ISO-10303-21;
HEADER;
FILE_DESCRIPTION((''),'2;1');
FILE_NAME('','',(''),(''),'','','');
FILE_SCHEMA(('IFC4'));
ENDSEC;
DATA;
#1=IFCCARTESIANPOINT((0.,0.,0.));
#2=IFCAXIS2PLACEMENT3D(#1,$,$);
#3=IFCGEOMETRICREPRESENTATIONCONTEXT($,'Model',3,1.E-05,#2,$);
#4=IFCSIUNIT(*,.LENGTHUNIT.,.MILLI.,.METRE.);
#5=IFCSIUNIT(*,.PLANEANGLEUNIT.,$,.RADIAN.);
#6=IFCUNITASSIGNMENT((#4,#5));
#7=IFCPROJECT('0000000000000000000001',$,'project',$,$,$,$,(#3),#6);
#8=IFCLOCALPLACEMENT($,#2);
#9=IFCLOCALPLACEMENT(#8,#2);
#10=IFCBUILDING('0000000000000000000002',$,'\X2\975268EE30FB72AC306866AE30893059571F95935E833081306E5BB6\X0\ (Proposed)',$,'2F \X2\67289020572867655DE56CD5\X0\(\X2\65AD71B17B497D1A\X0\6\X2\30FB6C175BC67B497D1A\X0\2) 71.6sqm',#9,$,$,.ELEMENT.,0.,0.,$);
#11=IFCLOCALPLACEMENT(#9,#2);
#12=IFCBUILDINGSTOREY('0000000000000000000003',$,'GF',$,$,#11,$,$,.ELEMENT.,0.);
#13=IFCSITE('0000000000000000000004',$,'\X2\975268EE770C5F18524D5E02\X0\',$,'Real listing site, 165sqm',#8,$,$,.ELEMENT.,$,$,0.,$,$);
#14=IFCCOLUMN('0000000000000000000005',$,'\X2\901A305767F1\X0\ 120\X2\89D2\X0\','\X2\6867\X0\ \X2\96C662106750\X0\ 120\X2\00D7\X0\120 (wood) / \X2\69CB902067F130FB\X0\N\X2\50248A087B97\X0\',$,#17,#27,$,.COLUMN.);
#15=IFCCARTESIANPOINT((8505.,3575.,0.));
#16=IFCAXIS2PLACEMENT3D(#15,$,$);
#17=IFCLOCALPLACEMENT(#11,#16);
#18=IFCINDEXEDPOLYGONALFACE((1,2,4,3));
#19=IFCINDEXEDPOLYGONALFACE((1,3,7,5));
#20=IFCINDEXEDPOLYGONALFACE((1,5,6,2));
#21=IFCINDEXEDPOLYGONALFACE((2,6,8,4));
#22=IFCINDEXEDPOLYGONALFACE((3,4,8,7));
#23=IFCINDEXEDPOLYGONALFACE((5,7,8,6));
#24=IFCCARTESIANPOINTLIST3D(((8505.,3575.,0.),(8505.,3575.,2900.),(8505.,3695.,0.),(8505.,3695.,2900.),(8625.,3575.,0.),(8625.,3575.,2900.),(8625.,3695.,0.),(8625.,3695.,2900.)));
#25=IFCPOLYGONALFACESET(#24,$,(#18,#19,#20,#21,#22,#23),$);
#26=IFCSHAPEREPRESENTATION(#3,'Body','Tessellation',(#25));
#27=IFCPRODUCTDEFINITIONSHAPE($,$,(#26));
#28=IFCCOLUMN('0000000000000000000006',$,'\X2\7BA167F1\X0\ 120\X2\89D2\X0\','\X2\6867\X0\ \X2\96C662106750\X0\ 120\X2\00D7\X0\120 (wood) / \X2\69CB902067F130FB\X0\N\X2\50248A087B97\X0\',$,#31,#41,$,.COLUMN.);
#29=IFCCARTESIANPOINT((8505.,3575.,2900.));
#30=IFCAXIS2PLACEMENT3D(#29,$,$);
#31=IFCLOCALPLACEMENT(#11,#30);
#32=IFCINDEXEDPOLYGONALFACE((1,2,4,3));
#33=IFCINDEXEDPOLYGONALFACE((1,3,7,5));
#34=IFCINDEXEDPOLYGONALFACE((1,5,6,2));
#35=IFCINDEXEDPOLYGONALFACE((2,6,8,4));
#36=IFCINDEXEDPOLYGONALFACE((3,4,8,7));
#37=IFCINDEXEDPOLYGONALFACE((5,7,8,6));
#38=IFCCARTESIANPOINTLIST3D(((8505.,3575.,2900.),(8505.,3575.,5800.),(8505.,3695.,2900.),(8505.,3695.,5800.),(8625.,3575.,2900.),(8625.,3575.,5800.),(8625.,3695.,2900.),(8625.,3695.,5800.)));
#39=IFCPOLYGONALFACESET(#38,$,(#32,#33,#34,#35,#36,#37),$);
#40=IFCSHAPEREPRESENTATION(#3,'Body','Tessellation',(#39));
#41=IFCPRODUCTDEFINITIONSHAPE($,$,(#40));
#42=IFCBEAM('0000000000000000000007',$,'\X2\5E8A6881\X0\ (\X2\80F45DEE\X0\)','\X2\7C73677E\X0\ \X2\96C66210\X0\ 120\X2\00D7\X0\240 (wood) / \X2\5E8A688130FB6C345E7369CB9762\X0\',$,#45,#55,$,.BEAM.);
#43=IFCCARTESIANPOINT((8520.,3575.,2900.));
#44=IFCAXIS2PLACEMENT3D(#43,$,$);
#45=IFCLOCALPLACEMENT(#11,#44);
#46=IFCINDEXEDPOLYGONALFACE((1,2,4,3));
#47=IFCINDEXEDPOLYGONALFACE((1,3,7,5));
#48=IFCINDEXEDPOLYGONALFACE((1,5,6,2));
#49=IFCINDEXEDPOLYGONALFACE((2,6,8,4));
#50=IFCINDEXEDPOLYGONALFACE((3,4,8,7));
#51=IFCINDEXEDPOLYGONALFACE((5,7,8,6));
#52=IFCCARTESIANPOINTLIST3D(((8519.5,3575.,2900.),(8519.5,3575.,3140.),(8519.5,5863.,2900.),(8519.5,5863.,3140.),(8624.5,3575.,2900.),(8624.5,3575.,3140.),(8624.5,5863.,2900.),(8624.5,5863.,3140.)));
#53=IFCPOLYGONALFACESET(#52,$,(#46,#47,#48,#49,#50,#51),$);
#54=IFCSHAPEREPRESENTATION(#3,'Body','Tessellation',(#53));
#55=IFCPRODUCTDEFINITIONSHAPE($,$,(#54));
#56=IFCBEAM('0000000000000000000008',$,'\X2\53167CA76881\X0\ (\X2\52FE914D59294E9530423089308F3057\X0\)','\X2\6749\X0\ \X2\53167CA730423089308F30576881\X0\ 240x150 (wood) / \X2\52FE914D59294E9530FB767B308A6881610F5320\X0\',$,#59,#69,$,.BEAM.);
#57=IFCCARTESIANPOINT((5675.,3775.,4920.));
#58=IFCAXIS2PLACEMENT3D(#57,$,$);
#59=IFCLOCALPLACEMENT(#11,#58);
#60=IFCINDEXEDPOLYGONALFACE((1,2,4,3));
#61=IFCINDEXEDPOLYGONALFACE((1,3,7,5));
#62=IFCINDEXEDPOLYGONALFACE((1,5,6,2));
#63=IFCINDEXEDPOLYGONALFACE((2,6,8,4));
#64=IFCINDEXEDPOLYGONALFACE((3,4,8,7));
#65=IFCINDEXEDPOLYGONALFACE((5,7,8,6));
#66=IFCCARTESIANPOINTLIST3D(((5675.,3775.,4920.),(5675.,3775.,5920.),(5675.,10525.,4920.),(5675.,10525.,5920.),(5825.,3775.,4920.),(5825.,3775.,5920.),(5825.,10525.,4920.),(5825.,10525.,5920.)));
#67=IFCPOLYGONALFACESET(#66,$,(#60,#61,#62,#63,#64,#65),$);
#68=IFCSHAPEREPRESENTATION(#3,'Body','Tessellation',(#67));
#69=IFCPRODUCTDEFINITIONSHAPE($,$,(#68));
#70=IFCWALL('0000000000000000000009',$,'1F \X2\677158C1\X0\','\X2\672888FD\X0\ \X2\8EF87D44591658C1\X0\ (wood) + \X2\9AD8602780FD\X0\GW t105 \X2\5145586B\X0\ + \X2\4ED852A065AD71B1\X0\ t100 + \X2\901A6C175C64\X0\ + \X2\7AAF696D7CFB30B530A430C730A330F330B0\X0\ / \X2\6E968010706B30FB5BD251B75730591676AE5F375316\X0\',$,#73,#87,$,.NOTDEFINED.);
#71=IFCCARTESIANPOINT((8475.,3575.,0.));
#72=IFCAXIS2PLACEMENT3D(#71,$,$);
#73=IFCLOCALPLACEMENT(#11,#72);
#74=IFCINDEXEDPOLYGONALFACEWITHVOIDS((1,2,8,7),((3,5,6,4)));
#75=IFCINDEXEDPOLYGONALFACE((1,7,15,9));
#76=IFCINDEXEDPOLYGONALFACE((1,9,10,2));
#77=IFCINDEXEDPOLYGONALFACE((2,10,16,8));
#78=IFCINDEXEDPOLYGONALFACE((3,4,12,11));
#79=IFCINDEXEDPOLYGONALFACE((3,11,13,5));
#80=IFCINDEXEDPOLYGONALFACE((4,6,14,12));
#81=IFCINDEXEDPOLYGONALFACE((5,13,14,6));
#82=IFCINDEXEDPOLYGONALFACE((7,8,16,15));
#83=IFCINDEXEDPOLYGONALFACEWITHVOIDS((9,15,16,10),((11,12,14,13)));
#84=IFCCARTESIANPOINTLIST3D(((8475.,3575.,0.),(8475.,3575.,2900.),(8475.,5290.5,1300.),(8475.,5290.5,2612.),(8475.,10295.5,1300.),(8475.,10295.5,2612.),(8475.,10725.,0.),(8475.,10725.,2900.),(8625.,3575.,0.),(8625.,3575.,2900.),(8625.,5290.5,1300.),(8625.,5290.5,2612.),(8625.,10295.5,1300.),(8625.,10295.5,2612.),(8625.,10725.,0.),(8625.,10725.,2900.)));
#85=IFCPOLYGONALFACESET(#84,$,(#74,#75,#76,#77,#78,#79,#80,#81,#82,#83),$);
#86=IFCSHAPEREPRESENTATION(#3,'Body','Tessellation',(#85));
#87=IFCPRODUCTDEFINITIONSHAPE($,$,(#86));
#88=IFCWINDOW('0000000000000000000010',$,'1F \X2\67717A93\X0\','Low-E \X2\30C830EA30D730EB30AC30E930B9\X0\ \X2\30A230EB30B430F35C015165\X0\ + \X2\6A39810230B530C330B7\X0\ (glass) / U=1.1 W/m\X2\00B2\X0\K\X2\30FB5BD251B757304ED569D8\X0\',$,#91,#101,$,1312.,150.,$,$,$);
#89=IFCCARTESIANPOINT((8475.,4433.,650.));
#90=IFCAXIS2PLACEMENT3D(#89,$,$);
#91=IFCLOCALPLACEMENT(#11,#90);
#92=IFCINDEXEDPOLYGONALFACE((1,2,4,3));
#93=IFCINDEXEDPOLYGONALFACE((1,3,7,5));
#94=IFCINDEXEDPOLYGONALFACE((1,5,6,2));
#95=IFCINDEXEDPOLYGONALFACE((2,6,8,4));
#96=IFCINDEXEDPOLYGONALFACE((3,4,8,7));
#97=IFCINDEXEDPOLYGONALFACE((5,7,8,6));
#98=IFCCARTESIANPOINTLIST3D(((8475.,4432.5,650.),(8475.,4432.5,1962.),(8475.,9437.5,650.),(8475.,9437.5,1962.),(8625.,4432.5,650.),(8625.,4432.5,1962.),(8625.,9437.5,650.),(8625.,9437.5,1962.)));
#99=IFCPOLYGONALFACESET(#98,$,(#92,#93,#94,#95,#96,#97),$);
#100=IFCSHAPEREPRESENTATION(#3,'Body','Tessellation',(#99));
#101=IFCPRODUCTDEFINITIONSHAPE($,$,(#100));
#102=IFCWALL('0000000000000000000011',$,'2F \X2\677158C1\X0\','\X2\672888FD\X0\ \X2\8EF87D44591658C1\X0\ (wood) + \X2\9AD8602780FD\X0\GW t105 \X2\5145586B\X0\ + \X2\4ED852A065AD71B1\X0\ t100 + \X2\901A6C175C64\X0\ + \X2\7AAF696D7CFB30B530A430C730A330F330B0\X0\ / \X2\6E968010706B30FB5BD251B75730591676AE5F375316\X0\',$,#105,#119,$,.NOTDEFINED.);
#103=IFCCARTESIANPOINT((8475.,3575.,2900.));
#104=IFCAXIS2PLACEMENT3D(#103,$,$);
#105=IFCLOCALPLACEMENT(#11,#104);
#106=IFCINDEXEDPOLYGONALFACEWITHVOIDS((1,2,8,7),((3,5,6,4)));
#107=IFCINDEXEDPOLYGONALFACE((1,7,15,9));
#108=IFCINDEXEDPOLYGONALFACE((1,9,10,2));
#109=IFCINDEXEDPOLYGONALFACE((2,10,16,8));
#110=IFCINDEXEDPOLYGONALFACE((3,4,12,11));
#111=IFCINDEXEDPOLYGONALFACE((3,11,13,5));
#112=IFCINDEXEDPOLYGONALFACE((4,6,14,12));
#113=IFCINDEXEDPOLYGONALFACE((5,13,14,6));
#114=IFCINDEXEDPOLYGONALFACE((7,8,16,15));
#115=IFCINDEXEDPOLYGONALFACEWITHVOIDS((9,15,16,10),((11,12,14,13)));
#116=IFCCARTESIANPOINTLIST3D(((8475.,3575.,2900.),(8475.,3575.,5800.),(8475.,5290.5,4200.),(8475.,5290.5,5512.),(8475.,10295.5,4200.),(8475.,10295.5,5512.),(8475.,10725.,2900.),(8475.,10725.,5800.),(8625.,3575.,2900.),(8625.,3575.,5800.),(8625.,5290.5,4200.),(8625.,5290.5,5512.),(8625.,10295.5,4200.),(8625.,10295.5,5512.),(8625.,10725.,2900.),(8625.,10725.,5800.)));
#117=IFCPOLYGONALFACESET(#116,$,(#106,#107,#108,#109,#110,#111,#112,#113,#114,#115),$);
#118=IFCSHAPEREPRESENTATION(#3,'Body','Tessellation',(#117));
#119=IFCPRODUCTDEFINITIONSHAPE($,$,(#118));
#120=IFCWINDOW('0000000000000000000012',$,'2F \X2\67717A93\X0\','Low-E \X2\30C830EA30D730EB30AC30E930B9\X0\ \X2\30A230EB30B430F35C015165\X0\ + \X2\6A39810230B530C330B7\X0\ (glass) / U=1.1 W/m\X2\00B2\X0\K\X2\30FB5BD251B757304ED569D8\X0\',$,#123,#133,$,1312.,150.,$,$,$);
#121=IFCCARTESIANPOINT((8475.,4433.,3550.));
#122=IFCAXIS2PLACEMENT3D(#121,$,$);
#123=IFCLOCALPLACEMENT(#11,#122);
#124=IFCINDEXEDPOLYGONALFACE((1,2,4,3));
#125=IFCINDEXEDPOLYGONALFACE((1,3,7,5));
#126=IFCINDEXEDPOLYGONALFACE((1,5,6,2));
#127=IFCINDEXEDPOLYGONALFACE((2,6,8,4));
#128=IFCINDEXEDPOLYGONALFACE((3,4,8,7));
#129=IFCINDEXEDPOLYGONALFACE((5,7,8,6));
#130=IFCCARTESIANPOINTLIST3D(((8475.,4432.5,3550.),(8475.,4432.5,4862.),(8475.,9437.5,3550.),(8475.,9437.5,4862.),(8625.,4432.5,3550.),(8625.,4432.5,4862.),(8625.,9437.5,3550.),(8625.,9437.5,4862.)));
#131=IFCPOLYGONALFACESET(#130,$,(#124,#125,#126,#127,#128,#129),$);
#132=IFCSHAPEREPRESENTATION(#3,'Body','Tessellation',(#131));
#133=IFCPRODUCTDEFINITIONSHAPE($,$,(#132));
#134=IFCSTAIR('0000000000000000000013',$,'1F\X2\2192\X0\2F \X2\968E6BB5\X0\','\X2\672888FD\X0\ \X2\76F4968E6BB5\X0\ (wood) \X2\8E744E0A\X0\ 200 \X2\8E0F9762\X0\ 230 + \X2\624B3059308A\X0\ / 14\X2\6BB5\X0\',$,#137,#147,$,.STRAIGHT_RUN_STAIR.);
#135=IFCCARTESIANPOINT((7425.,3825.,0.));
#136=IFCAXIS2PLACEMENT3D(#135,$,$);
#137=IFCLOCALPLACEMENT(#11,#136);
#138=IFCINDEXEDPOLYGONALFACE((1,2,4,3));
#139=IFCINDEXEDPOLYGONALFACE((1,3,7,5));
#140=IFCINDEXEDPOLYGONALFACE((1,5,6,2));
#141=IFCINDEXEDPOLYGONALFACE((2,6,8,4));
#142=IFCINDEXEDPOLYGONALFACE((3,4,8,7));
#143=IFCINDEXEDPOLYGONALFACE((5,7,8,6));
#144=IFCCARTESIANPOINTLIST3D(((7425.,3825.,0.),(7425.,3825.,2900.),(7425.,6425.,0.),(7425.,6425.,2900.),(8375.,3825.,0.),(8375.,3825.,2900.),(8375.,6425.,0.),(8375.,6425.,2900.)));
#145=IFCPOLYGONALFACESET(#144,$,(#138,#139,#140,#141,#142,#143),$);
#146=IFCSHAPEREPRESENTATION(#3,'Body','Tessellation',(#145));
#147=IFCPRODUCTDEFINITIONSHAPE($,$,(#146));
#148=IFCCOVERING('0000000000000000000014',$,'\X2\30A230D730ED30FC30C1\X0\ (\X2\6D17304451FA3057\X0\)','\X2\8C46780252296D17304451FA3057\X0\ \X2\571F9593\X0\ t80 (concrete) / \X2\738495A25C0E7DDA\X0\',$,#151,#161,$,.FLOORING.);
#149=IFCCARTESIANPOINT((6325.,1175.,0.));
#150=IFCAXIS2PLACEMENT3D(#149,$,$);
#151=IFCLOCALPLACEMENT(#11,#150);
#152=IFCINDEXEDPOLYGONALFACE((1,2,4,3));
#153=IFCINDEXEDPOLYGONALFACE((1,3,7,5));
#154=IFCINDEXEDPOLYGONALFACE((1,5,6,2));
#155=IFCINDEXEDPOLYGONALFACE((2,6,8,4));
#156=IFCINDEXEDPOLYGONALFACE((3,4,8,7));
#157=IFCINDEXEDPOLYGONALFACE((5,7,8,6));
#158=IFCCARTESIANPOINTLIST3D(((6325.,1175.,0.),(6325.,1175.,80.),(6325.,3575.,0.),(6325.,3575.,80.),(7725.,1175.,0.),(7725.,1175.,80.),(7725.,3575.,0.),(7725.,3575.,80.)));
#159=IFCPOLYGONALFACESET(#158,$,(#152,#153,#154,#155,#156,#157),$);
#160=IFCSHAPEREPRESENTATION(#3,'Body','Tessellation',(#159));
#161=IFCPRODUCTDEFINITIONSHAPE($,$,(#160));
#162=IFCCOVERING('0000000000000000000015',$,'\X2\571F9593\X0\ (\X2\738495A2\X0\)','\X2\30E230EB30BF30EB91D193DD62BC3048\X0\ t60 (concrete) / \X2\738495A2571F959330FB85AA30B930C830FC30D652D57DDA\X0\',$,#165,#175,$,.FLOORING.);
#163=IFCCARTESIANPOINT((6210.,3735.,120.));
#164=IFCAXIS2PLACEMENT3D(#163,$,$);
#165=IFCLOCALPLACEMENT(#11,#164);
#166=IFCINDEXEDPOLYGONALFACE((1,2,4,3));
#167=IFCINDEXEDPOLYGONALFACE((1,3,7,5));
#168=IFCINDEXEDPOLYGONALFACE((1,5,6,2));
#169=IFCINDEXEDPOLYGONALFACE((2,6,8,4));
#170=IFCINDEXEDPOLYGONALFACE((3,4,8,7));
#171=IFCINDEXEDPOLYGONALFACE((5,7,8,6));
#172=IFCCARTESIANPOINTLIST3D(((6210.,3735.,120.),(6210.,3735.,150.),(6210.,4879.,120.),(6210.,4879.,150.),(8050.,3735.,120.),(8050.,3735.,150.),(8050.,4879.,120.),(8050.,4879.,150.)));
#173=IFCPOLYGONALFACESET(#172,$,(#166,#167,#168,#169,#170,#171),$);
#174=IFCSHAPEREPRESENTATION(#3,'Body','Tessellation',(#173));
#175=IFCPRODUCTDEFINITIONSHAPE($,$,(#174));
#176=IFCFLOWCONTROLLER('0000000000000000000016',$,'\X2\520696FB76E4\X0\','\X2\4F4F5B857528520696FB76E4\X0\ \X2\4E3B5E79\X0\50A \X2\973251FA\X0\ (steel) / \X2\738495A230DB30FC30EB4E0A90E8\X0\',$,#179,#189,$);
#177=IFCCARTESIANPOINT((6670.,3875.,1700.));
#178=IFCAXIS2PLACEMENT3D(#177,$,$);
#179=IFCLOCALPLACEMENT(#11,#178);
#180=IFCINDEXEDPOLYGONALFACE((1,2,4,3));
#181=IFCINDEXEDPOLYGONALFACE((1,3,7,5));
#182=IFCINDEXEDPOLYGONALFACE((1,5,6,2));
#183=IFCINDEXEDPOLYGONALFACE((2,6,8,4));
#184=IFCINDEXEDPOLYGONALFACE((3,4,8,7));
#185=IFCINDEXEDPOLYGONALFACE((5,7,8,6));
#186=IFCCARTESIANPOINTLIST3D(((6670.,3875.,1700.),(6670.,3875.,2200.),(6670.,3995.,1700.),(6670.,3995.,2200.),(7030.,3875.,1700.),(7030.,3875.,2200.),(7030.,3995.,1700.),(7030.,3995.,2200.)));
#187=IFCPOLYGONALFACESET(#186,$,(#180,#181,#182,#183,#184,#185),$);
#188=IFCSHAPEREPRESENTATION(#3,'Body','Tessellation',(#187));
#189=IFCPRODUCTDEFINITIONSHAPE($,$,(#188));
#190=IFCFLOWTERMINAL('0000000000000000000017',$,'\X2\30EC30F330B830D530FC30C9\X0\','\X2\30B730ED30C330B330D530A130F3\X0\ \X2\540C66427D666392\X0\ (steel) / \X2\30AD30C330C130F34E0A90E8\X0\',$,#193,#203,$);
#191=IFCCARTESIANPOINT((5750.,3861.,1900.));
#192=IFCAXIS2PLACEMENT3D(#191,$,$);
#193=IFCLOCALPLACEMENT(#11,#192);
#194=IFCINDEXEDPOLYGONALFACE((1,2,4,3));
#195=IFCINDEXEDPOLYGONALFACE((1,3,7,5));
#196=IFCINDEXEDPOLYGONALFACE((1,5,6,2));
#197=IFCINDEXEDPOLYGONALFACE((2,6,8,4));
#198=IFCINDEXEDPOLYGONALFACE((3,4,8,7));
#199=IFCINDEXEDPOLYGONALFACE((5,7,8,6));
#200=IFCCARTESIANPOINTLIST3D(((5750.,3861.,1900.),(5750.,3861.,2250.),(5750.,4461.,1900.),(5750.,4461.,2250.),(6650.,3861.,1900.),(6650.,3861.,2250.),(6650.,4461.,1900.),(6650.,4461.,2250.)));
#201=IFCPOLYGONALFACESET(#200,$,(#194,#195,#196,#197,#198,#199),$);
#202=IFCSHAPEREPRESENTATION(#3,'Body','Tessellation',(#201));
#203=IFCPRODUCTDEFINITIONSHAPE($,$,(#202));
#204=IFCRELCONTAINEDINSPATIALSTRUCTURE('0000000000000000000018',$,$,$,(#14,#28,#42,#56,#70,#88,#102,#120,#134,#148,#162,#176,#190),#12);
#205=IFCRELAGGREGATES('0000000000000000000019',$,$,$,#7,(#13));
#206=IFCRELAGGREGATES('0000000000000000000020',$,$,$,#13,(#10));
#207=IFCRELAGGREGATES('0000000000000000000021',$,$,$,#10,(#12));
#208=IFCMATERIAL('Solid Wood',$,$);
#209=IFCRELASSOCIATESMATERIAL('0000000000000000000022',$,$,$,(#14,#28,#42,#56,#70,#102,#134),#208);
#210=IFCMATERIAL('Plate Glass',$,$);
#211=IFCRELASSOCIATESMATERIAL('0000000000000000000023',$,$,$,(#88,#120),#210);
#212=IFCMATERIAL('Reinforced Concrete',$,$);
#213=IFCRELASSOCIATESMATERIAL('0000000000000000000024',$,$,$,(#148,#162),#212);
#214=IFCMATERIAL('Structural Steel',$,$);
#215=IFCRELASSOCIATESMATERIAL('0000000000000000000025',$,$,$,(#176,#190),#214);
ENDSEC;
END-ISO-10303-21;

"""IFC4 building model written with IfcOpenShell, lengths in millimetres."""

from ifc_helpers import new_model, si_unit, frame, frame_2d, origin, place, context, project, spatial, rectangle, extrude, material, element, fill, save


model = new_model("IFC4")

# Units and contexts
model_context = context("Model", 3, precision=1e-05, world=origin())
ifc_project = project(units=[si_unit("LENGTHUNIT", "METRE", prefix="MILLI"), si_unit("PLANEANGLEUNIT", "RADIAN")], contexts=[model_context])

# Site, building, storey
site_placement = place(None, origin())
site = spatial("IfcSite", under=ifc_project, at=site_placement, Name="青森県弘前市", ObjectType="Real listing site, 165sqm", CompositionType="ELEMENT", RefElevation=0.0)
building_placement = place(site_placement, origin())
building = spatial("IfcBuilding", under=site, at=building_placement, Name="青森・犬と暮らす土間広めの家 (Proposed)", ObjectType="2F 木造在来工法(断熱等級6・気密等級2) 71.6sqm", CompositionType="ELEMENT", ElevationOfRefHeight=0.0, ElevationOfTerrain=0.0)
storey_placement = place(building_placement, origin())
storey = spatial("IfcBuildingStorey", under=building, at=storey_placement, Name="GF", CompositionType="ELEMENT", Elevation=0.0)

# Columns
ifc_material_1 = material(Name="Solid Wood")
column_1_placement = place(storey_placement, frame((8505.0, 3575.0, 0.0)))
element("IfcColumn", 1, at=column_1_placement, inside=storey, material=ifc_material_1, Name="通し柱 120角", Description="桧 集成材 120×120 (wood) / 構造柱・N値計算", PredefinedType="COLUMN", context=model_context, shape_type="SweptSolid", body=[
    extrude(rectangle(XDim=120.0, YDim=120.0, at=frame_2d((60.0, 60.0))), frame((8505.0, 3575.0, 0.0)), (0.0, 0.0, 1.0), 2900.0),
])
column_2_placement = place(storey_placement, frame((8505.0, 3575.0, 2900.0)))
element("IfcColumn", 2, at=column_2_placement, inside=storey, material=ifc_material_1, Name="管柱 120角", Description="桧 集成材 120×120 (wood) / 構造柱・N値計算", PredefinedType="COLUMN", context=model_context, shape_type="SweptSolid", body=[
    extrude(rectangle(XDim=120.0, YDim=120.0, at=frame_2d((60.0, 60.0))), frame((8505.0, 3575.0, 2900.0)), (0.0, 0.0, 1.0), 2900.0),
])

# Beams
beam_1_placement = place(storey_placement, frame((8520.0, 3575.0, 2900.0)))
element("IfcBeam", 3, at=beam_1_placement, inside=storey, material=ifc_material_1, Name="床梁 (胴差)", Description="米松 集成 120×240 (wood) / 床梁・水平構面", PredefinedType="BEAM", context=model_context, shape_type="SweptSolid", body=[
    extrude(rectangle(XDim=105.0, YDim=2288.0, at=frame_2d((52.0, 1144.0))), frame((8520.0, 3575.0, 2900.0)), (0.0, 0.0, 1.0), 240.0),
])
beam_2_placement = place(storey_placement, frame((5675.0, 3775.0, 4920.0)))
element("IfcBeam", 4, at=beam_2_placement, inside=storey, material=ifc_material_1, Name="化粧梁 (勾配天井あらわし)", Description="杉 化粧あらわし梁 240x150 (wood) / 勾配天井・登り梁意匠", PredefinedType="BEAM", context=model_context, shape_type="SweptSolid", body=[
    extrude(rectangle(XDim=150.0, YDim=6750.0, at=frame_2d((75.0, 3375.0))), frame((5675.0, 3775.0, 4920.0)), (0.0, 0.0, 1.0), 1000.0),
])

# Wall, opening, window
wall_1_placement = place(storey_placement, frame((8475.0, 3575.0, 0.0)))
wall_1 = element("IfcWall", 5, at=wall_1_placement, inside=storey, material=ifc_material_1, Name="1F 東壁", Description="木製 軸組外壁 (wood) + 高性能GW t105 充填 + 付加断熱 t100 + 通気層 + 窯業系サイディング / 準耐火・寒冷地外皮強化", PredefinedType="NOTDEFINED", context=model_context, shape_type="SweptSolid", body=[
    extrude(rectangle(XDim=150.0, YDim=7150.0, at=frame_2d((75.0, 3575.0))), frame((8475.0, 3575.0, 0.0)), (0.0, 0.0, 1.0), 2900.0),
])
opening_1_placement = place(storey_placement, frame((8475.0, 4433.0, 650.0)))
opening_1 = element("IfcOpeningElement", 6, at=opening_1_placement, cuts=wall_1, PredefinedType="NOTDEFINED", context=model_context, shape_type="SweptSolid", body=[
    extrude(rectangle(XDim=150.0, YDim=5005.0, at=frame_2d((75.0, 2502.0))), frame((8475.0, 4433.0, 650.0)), (0.0, 0.0, 1.0), 1312.0),
])
ifc_material_2 = material(Name="Plate Glass")
window_1_placement = place(storey_placement, frame((8475.0, 4433.0, 650.0)))
window_1 = element("IfcWindow", 7, at=window_1_placement, inside=storey, material=ifc_material_2, Name="1F 東窓", Description="Low-E トリプルガラス アルゴン封入 + 樹脂サッシ (glass) / U=1.1 W/m²K・寒冷地仕様", OverallHeight=1312.0, OverallWidth=150.0, context=model_context, shape_type="SweptSolid", body=[
    extrude(rectangle(XDim=150.0, YDim=5005.0, at=frame_2d((75.0, 2502.0))), frame((8475.0, 4433.0, 650.0)), (0.0, 0.0, 1.0), 1312.0),
])
fill(opening_1, window_1)

# Wall, opening, window
wall_2_placement = place(storey_placement, frame((8475.0, 3575.0, 2900.0)))
wall_2 = element("IfcWall", 8, at=wall_2_placement, inside=storey, material=ifc_material_1, Name="2F 東壁", Description="木製 軸組外壁 (wood) + 高性能GW t105 充填 + 付加断熱 t100 + 通気層 + 窯業系サイディング / 準耐火・寒冷地外皮強化", PredefinedType="NOTDEFINED", context=model_context, shape_type="SweptSolid", body=[
    extrude(rectangle(XDim=150.0, YDim=7150.0, at=frame_2d((75.0, 3575.0))), frame((8475.0, 3575.0, 2900.0)), (0.0, 0.0, 1.0), 2900.0),
])
opening_2_placement = place(storey_placement, frame((8475.0, 4433.0, 3550.0)))
opening_2 = element("IfcOpeningElement", 9, at=opening_2_placement, cuts=wall_2, PredefinedType="NOTDEFINED", context=model_context, shape_type="SweptSolid", body=[
    extrude(rectangle(XDim=150.0, YDim=5005.0, at=frame_2d((75.0, 2502.0))), frame((8475.0, 4433.0, 3550.0)), (0.0, 0.0, 1.0), 1312.0),
])
window_2_placement = place(storey_placement, frame((8475.0, 4433.0, 3550.0)))
window_2 = element("IfcWindow", 10, at=window_2_placement, inside=storey, material=ifc_material_2, Name="2F 東窓", Description="Low-E トリプルガラス アルゴン封入 + 樹脂サッシ (glass) / U=1.1 W/m²K・寒冷地仕様", OverallHeight=1312.0, OverallWidth=150.0, context=model_context, shape_type="SweptSolid", body=[
    extrude(rectangle(XDim=150.0, YDim=5005.0, at=frame_2d((75.0, 2502.0))), frame((8475.0, 4433.0, 3550.0)), (0.0, 0.0, 1.0), 1312.0),
])
fill(opening_2, window_2)

# Stair
stair_placement = place(storey_placement, frame((7425.0, 3825.0, 0.0)))
element("IfcStair", 11, at=stair_placement, inside=storey, material=ifc_material_1, Name="1F→2F 階段", Description="木製 直階段 (wood) 蹴上 200 踏面 230 + 手すり / 14段", PredefinedType="STRAIGHT_RUN_STAIR", context=model_context, shape_type="SweptSolid", body=[
    extrude(rectangle(XDim=950.0, YDim=2600.0, at=frame_2d((475.0, 1300.0))), frame((7425.0, 3825.0, 0.0)), (0.0, 0.0, 1.0), 2900.0),
])

# Coverings
ifc_material_3 = material(Name="Reinforced Concrete")
covering_1_placement = place(storey_placement, frame((6325.0, 1175.0, 0.0)))
element("IfcCovering", 12, at=covering_1_placement, inside=storey, material=ifc_material_3, Name="アプローチ (洗い出し)", Description="豆砂利洗い出し 土間 t80 (concrete) / 玄関導線", PredefinedType="FLOORING", context=model_context, shape_type="SweptSolid", body=[
    extrude(rectangle(XDim=1400.0, YDim=2400.0, at=frame_2d((700.0, 1200.0))), frame((6325.0, 1175.0, 0.0)), (0.0, 0.0, 1.0), 80.0),
])
covering_2_placement = place(storey_placement, frame((6210.0, 3735.0, 120.0)))
element("IfcCovering", 13, at=covering_2_placement, inside=storey, material=ifc_material_3, Name="土間 (玄関)", Description="モルタル金鏝押え t60 (concrete) / 玄関土間・薪ストーブ動線", PredefinedType="FLOORING", context=model_context, shape_type="SweptSolid", body=[
    extrude(rectangle(XDim=1840.0, YDim=1144.0, at=frame_2d((920.0, 572.0))), frame((6210.0, 3735.0, 120.0)), (0.0, 0.0, 1.0), 30.0),
])

# Flow controller
ifc_material_4 = material(Name="Structural Steel")
flow_controller_placement = place(storey_placement, frame((6670.0, 3875.0, 1700.0)))
element("IfcFlowController", 14, at=flow_controller_placement, inside=storey, material=ifc_material_4, Name="分電盤", Description="住宅用分電盤 主幹50A 露出 (steel) / 玄関ホール上部", context=model_context, shape_type="SweptSolid", body=[
    extrude(rectangle(XDim=360.0, YDim=120.0, at=frame_2d((180.0, 60.0))), frame((6670.0, 3875.0, 1700.0)), (0.0, 0.0, 1.0), 500.0),
])

# Flow terminal
flow_terminal_1_placement = place(storey_placement, frame((5750.0, 3861.0, 1900.0)))
element("IfcFlowTerminal", 15, at=flow_terminal_1_placement, inside=storey, material=ifc_material_4, Name="レンジフード", Description="シロッコファン 同時給排 (steel) / キッチン上部", context=model_context, shape_type="SweptSolid", body=[
    extrude(rectangle(XDim=900.0, YDim=600.0, at=frame_2d((450.0, 300.0))), frame((5750.0, 3861.0, 1900.0)), (0.0, 0.0, 1.0), 350.0),
])

save(model, "model.ifc")
